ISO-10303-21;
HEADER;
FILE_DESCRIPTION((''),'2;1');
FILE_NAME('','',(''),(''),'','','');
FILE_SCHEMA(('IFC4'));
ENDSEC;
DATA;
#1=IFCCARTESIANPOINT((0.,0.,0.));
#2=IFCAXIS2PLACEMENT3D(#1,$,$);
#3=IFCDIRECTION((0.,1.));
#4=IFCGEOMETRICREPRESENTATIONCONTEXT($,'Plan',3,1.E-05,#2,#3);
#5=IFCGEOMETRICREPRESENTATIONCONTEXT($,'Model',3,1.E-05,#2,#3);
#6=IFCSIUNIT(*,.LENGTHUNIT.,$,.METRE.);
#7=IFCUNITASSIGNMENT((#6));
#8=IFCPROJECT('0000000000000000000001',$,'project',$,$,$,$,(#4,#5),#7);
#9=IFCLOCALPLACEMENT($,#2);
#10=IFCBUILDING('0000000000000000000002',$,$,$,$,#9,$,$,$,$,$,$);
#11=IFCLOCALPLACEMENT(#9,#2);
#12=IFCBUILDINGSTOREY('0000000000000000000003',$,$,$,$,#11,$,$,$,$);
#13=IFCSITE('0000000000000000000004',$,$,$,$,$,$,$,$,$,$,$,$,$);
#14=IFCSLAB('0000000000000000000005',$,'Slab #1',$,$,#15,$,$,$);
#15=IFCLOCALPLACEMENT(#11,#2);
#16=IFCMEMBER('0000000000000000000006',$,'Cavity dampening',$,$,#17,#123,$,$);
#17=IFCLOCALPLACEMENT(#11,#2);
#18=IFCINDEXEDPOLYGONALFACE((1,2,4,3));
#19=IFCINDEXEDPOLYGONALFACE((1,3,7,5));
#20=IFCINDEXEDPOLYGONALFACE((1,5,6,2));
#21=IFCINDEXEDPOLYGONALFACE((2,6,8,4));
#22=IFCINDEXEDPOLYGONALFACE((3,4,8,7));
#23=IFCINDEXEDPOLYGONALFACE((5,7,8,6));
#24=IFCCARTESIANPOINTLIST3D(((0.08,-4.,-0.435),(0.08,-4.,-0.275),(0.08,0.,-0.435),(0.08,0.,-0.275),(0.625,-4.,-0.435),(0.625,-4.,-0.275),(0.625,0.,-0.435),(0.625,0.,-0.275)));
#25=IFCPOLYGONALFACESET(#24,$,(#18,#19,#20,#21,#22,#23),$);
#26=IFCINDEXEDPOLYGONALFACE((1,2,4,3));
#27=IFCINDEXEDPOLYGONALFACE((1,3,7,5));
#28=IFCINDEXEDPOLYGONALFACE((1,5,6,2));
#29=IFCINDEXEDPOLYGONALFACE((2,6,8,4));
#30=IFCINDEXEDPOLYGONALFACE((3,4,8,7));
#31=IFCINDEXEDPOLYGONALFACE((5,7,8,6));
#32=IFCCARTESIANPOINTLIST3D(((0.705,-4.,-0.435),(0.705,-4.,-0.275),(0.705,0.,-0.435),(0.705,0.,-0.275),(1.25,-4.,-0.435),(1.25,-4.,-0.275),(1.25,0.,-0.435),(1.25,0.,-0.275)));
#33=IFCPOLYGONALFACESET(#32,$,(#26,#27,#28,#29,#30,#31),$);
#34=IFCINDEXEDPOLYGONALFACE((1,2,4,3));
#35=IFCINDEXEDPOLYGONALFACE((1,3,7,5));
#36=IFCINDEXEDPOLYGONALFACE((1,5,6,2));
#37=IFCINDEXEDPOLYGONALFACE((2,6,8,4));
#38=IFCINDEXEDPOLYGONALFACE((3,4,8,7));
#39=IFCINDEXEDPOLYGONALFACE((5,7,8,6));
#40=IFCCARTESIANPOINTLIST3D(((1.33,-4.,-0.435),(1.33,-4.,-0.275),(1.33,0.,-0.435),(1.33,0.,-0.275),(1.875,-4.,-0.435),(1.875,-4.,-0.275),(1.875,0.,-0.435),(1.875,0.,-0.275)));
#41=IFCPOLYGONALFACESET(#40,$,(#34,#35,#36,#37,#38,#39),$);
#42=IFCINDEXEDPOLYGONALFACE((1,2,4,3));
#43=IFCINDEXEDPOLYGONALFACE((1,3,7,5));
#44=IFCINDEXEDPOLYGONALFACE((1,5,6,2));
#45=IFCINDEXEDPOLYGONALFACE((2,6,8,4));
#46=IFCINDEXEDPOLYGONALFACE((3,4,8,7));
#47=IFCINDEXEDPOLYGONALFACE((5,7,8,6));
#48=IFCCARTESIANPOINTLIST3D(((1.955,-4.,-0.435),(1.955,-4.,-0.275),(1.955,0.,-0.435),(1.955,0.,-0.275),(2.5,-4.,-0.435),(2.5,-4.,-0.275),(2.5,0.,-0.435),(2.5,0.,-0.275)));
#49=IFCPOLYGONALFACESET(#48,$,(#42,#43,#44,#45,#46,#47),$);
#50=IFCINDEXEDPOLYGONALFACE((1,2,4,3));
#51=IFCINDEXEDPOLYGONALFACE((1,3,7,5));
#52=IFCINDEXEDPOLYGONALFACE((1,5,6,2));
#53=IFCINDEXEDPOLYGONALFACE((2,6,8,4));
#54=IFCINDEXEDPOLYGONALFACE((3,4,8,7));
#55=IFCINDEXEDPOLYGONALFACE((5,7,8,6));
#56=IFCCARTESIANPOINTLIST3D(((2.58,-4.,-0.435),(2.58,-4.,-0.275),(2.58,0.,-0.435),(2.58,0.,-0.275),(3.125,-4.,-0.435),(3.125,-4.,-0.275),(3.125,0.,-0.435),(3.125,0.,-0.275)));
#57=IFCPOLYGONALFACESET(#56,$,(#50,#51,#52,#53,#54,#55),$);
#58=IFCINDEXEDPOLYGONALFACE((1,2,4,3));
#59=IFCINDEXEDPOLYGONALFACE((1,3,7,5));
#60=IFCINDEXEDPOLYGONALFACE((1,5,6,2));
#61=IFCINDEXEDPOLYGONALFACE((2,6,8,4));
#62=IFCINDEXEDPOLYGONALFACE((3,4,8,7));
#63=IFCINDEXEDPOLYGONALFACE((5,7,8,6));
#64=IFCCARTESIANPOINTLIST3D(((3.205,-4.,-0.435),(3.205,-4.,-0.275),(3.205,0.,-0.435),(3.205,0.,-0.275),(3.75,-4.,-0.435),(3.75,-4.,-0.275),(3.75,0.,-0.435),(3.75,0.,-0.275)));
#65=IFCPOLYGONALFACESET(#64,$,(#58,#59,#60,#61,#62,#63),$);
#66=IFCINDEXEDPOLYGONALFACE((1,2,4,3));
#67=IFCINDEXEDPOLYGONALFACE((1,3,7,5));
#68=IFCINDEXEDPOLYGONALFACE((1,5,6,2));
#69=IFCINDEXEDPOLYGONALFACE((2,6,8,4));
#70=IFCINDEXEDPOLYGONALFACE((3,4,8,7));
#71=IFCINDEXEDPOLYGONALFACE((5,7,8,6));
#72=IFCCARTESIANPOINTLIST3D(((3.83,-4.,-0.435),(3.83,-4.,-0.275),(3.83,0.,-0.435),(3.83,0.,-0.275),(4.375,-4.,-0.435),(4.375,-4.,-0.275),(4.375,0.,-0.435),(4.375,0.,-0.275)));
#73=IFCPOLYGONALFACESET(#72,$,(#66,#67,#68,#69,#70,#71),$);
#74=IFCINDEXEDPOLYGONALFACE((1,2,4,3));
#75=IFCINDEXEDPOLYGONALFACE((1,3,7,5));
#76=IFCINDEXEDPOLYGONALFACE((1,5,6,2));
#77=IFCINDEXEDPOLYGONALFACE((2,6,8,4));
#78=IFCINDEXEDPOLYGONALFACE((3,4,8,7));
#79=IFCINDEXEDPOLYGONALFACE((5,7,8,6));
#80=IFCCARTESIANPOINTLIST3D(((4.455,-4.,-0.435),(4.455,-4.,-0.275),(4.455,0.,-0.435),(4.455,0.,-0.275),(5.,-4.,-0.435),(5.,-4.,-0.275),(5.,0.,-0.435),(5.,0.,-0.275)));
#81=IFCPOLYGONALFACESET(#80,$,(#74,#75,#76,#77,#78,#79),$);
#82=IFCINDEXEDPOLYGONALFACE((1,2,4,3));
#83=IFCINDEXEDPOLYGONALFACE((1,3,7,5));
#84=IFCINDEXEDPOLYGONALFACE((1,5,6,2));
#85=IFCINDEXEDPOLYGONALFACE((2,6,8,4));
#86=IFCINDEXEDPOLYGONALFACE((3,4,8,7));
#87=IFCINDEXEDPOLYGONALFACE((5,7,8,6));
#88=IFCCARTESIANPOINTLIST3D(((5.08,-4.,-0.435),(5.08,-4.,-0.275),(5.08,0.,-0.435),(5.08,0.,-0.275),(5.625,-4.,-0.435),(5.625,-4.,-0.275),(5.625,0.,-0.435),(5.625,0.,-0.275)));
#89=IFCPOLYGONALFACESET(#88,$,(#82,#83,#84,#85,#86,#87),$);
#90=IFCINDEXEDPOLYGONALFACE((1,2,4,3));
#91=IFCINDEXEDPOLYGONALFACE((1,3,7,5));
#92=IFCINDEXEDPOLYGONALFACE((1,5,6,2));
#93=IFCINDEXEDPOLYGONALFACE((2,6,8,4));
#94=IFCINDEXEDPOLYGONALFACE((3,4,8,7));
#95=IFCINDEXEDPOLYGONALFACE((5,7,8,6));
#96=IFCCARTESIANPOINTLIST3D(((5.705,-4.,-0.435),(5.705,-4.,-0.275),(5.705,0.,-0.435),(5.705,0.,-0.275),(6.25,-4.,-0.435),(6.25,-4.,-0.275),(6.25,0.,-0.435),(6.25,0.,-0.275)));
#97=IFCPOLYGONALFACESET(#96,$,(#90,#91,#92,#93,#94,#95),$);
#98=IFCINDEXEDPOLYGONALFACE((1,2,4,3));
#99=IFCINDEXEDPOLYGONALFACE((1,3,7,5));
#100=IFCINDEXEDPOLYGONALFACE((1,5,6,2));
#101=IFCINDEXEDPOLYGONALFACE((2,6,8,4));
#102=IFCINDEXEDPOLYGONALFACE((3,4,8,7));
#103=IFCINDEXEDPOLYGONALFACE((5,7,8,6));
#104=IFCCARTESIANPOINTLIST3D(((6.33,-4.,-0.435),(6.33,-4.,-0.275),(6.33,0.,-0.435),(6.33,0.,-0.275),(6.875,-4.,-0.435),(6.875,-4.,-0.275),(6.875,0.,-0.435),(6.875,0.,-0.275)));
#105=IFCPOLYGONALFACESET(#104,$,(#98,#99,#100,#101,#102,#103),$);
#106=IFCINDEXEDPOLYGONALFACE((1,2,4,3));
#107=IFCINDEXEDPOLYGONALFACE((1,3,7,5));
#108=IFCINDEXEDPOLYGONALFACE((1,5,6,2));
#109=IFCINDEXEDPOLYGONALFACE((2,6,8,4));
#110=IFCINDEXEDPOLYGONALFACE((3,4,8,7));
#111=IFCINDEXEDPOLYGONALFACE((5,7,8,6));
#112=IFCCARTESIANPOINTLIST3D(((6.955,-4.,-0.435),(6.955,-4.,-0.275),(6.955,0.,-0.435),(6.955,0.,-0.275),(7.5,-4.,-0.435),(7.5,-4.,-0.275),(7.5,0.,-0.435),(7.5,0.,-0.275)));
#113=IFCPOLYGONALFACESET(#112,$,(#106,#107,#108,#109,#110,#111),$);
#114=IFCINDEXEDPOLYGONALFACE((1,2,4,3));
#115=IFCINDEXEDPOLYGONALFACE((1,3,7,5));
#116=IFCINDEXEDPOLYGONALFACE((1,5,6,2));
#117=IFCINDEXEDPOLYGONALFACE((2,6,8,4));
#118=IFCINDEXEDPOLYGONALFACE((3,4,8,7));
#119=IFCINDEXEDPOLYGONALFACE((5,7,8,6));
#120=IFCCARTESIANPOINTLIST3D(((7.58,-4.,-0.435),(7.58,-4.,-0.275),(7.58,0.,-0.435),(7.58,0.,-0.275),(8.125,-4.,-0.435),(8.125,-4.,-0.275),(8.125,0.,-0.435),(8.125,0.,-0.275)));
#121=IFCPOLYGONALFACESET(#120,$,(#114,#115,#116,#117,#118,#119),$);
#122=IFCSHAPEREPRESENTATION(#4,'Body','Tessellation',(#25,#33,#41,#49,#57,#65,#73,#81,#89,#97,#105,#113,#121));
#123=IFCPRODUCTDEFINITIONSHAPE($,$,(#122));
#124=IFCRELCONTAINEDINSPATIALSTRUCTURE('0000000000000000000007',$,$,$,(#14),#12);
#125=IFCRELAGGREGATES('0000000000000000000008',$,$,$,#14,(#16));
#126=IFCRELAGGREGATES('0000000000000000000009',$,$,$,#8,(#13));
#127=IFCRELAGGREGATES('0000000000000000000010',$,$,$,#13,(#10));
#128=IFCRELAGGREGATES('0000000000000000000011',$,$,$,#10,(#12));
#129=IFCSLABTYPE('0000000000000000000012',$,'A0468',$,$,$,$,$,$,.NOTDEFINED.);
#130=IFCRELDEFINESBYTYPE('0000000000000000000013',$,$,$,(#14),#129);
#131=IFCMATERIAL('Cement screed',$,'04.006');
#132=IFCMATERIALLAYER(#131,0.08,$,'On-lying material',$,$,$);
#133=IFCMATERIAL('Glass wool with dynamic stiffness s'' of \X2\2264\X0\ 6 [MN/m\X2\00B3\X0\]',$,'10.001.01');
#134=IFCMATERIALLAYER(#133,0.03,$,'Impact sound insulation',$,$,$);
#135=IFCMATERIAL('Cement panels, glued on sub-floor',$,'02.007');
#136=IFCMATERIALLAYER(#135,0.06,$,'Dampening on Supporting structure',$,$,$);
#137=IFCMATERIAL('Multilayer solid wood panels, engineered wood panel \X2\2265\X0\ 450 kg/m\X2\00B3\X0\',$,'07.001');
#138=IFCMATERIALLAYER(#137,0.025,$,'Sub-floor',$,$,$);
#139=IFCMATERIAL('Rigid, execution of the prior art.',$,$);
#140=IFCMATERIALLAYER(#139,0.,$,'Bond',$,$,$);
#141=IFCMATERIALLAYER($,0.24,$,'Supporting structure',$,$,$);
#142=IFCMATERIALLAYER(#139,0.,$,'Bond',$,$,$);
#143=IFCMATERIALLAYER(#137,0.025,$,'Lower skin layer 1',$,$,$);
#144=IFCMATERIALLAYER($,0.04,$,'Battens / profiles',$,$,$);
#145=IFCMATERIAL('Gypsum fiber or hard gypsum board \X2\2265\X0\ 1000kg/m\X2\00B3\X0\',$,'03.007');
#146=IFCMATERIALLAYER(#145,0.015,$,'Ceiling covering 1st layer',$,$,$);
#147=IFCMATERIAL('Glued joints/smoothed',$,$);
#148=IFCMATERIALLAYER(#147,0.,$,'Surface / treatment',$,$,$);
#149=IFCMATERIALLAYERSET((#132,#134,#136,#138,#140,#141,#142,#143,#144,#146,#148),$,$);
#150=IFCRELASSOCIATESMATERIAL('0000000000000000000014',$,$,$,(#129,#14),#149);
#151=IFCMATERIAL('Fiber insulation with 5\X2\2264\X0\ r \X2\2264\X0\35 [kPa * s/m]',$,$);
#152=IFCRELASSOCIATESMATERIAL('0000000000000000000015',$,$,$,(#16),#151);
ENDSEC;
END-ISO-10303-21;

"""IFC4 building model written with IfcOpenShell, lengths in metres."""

from ifc_helpers import new_model, si_unit, direction, frame, frame_2d, origin, place, context, project, spatial, rectangle, extrude, material, layer, layer_set, type_object, element, aggregate, save


model = new_model("IFC4")

# Units and contexts
plan_context = context("Plan", 3, precision=1e-05, world=origin(), true_north=direction((0.0, 1.0)))
model_context = context("Model", 3, precision=1e-05, world=origin(), true_north=direction((0.0, 1.0)))
ifc_project = project(units=[si_unit("LENGTHUNIT", "METRE")], contexts=[plan_context, model_context])

# Site, building, storey
site = spatial("IfcSite", under=ifc_project)
building_placement = place(None, origin())
building = spatial("IfcBuilding", under=site, at=building_placement)
storey_placement = place(building_placement, origin())
storey = spatial("IfcBuildingStorey", under=building, at=storey_placement)

# Slab, member
ifc_material_1 = material(Name="Cement screed", Category="04.006")
ifc_layer_1 = layer(ifc_material_1, 0.08, Name="On-lying material")
ifc_material_2 = material(Name="Glass wool with dynamic stiffness s' of ≤ 6 [MN/m³]", Category="10.001.01")
ifc_layer_2 = layer(ifc_material_2, 0.03, Name="Impact sound insulation")
ifc_material_3 = material(Name="Cement panels, glued on sub-floor", Category="02.007")
ifc_layer_3 = layer(ifc_material_3, 0.06, Name="Dampening on Supporting structure")
ifc_material_4 = material(Name="Multilayer solid wood panels, engineered wood panel ≥ 450 kg/m³", Category="07.001")
ifc_layer_4 = layer(ifc_material_4, 0.025, Name="Sub-floor")
ifc_material_5 = material(Name="Rigid, execution of the prior art.")
ifc_layer_5 = layer(ifc_material_5, 0.0, Name="Bond")
ifc_layer_6 = layer(None, 0.24, Name="Supporting structure")
ifc_layer_7 = layer(ifc_material_5, 0.0, Name="Bond")
ifc_layer_8 = layer(ifc_material_4, 0.025, Name="Lower skin layer 1")
ifc_layer_9 = layer(None, 0.04, Name="Battens / profiles")
ifc_material_6 = material(Name="Gypsum fiber or hard gypsum board ≥ 1000kg/m³", Category="03.007")
ifc_layer_10 = layer(ifc_material_6, 0.015, Name="Ceiling covering 1st layer")
ifc_material_7 = material(Name="Glued joints/smoothed")
ifc_layer_11 = layer(ifc_material_7, 0.0, Name="Surface / treatment")
ifc_layer_set = layer_set([ifc_layer_1, ifc_layer_2, ifc_layer_3, ifc_layer_4, ifc_layer_5, ifc_layer_6, ifc_layer_7, ifc_layer_8, ifc_layer_9, ifc_layer_10, ifc_layer_11])
slab_type = type_object("IfcSlabType", Name="A0468", PredefinedType="NOTDEFINED", material=ifc_layer_set)
slab_placement = place(None, frame((0.0, 0.0, 0.0), z_axis=(0.0, 0.0, -1.0), x_axis=(1.0, 0.0, 0.0)))
slab = element("IfcSlab", 1, at=slab_placement, inside=storey, type_object=slab_type, material=ifc_layer_set, Name="Slab #1")
ifc_material_8 = material(Name="Fiber insulation with 5≤ r ≤35 [kPa * s/m]")
member_1_placement = place(slab_placement, origin())
member_1 = element("IfcMember", 2, at=member_1_placement, material=ifc_material_8, Name="Cavity dampening", context=plan_context, shape_type="SweptSolid", body=[
    extrude(rectangle(XDim=0.545, YDim=0.16, at=frame_2d((0.2725, 0.08), x_axis=(1.0, 0.0))), frame((0.08, 4.0, 0.275), z_axis=(0.0, -1.0, 0.0), x_axis=(1.0, 0.0, 0.0)), (0.0, 0.0, 1.0), 4.0),
    extrude(rectangle(XDim=0.545, YDim=0.16, at=frame_2d((0.2725, 0.08), x_axis=(1.0, 0.0))), frame((0.705, 4.0, 0.275), z_axis=(0.0, -1.0, 0.0), x_axis=(1.0, 0.0, 0.0)), (0.0, 0.0, 1.0), 4.0),
    extrude(rectangle(XDim=0.545, YDim=0.16, at=frame_2d((0.2725, 0.08), x_axis=(1.0, 0.0))), frame((1.33, 4.0, 0.275), z_axis=(0.0, -1.0, 0.0), x_axis=(1.0, 0.0, 0.0)), (0.0, 0.0, 1.0), 4.0),
    extrude(rectangle(XDim=0.545, YDim=0.16, at=frame_2d((0.2725, 0.08), x_axis=(1.0, 0.0))), frame((1.955, 4.0, 0.275), z_axis=(0.0, -1.0, 0.0), x_axis=(1.0, 0.0, 0.0)), (0.0, 0.0, 1.0), 4.0),
    extrude(rectangle(XDim=0.545, YDim=0.16, at=frame_2d((0.2725, 0.08), x_axis=(1.0, 0.0))), frame((2.58, 4.0, 0.275), z_axis=(0.0, -1.0, 0.0), x_axis=(1.0, 0.0, 0.0)), (0.0, 0.0, 1.0), 4.0),
    extrude(rectangle(XDim=0.545, YDim=0.16, at=frame_2d((0.2725, 0.08), x_axis=(1.0, 0.0))), frame((3.205, 4.0, 0.275), z_axis=(0.0, -1.0, 0.0), x_axis=(1.0, 0.0, 0.0)), (0.0, 0.0, 1.0), 4.0),
    extrude(rectangle(XDim=0.545, YDim=0.16, at=frame_2d((0.2725, 0.08), x_axis=(1.0, 0.0))), frame((3.83, 4.0, 0.275), z_axis=(0.0, -1.0, 0.0), x_axis=(1.0, 0.0, 0.0)), (0.0, 0.0, 1.0), 4.0),
    extrude(rectangle(XDim=0.545, YDim=0.16, at=frame_2d((0.2725, 0.08), x_axis=(1.0, 0.0))), frame((4.455, 4.0, 0.275), z_axis=(0.0, -1.0, 0.0), x_axis=(1.0, 0.0, 0.0)), (0.0, 0.0, 1.0), 4.0),
    extrude(rectangle(XDim=0.545, YDim=0.16, at=frame_2d((0.2725, 0.08), x_axis=(1.0, 0.0))), frame((5.08, 4.0, 0.275), z_axis=(0.0, -1.0, 0.0), x_axis=(1.0, 0.0, 0.0)), (0.0, 0.0, 1.0), 4.0),
    extrude(rectangle(XDim=0.545, YDim=0.16, at=frame_2d((0.2725, 0.08), x_axis=(1.0, 0.0))), frame((5.705, 4.0, 0.275), z_axis=(0.0, -1.0, 0.0), x_axis=(1.0, 0.0, 0.0)), (0.0, 0.0, 1.0), 4.0),
    extrude(rectangle(XDim=0.545, YDim=0.16, at=frame_2d((0.2725, 0.08), x_axis=(1.0, 0.0))), frame((6.33, 4.0, 0.275), z_axis=(0.0, -1.0, 0.0), x_axis=(1.0, 0.0, 0.0)), (0.0, 0.0, 1.0), 4.0),
    extrude(rectangle(XDim=0.545, YDim=0.16, at=frame_2d((0.2725, 0.08), x_axis=(1.0, 0.0))), frame((6.955, 4.0, 0.275), z_axis=(0.0, -1.0, 0.0), x_axis=(1.0, 0.0, 0.0)), (0.0, 0.0, 1.0), 4.0),
    extrude(rectangle(XDim=0.545, YDim=0.16, at=frame_2d((0.2725, 0.08), x_axis=(1.0, 0.0))), frame((7.58, 4.0, 0.275), z_axis=(0.0, -1.0, 0.0), x_axis=(1.0, 0.0, 0.0)), (0.0, 0.0, 1.0), 4.0),
])
aggregate(slab, [member_1])

save(model, "model.ifc")
